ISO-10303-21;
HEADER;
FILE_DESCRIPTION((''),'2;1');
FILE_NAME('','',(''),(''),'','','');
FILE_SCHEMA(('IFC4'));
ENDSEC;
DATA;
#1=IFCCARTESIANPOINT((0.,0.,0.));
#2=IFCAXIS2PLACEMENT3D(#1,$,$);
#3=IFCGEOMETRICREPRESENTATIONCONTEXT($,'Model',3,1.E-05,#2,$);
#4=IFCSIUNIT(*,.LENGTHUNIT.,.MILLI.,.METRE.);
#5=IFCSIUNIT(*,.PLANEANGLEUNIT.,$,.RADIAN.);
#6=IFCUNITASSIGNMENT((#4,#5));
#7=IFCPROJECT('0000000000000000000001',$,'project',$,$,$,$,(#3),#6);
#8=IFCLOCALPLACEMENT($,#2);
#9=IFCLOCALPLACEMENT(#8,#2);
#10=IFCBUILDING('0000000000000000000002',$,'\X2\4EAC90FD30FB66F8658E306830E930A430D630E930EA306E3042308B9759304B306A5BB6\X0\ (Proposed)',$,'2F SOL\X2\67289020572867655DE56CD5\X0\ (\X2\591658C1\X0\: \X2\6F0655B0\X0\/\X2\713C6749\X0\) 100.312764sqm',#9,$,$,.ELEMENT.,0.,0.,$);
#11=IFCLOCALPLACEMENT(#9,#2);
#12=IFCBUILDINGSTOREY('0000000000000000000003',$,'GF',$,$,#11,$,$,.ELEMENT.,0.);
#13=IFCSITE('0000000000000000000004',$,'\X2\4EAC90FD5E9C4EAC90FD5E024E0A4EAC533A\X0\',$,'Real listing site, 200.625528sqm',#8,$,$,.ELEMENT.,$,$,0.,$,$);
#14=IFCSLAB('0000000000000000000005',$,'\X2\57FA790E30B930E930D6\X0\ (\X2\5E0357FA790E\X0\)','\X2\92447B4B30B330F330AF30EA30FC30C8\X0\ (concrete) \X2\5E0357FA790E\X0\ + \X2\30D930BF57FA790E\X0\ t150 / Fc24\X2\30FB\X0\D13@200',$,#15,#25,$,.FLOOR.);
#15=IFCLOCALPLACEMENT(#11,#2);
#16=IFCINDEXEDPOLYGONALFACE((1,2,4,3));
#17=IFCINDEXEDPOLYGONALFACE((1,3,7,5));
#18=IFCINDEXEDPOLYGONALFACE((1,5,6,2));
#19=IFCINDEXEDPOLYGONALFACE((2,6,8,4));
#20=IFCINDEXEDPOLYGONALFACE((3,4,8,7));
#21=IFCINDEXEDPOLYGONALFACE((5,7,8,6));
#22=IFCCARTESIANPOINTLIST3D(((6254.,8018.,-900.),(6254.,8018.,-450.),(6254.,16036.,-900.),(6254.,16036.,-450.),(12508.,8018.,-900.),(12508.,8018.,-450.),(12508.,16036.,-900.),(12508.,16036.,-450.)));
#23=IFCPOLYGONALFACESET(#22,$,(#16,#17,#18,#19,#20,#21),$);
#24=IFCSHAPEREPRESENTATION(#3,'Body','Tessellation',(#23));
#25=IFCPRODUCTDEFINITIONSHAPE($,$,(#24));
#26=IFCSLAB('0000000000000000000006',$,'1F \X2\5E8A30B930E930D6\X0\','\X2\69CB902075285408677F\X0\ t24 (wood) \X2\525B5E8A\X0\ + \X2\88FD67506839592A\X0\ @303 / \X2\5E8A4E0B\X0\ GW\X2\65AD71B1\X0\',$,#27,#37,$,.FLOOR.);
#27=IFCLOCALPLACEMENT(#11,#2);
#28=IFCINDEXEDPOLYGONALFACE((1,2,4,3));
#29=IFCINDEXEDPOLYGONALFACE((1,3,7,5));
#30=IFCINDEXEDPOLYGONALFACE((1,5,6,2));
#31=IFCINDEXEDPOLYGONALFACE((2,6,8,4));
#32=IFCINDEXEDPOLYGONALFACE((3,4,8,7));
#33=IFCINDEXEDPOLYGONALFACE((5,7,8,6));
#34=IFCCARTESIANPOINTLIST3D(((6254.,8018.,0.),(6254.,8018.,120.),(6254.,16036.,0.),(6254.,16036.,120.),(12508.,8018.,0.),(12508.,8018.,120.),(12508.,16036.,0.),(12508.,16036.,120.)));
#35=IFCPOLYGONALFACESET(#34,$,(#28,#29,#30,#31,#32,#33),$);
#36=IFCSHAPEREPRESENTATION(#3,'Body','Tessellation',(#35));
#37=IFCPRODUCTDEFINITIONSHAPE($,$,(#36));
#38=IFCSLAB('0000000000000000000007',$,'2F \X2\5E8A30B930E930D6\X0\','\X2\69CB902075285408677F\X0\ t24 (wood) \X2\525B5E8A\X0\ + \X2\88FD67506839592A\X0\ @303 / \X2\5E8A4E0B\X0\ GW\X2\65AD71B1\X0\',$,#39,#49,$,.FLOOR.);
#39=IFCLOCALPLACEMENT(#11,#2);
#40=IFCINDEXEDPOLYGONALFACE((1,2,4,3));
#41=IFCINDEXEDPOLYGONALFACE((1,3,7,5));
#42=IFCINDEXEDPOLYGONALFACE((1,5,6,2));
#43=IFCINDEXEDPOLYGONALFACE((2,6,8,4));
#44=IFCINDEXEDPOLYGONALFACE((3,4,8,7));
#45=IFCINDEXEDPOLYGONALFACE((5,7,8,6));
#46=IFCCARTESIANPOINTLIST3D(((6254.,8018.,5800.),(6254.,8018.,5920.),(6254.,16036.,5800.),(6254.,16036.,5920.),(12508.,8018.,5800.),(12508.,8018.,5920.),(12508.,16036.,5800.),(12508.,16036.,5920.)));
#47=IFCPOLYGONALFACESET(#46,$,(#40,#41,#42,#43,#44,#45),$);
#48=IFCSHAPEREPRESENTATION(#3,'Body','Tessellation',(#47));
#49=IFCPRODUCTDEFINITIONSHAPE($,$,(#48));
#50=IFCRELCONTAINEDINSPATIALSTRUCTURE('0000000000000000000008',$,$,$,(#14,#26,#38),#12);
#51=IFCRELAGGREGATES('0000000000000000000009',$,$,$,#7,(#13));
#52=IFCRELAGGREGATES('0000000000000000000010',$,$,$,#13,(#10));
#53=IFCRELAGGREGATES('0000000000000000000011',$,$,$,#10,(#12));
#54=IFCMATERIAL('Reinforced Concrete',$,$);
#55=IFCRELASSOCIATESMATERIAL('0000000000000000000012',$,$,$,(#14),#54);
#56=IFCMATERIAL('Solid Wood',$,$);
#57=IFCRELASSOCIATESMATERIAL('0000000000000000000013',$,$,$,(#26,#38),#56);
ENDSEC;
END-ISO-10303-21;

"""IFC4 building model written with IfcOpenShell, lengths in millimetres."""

from ifc_helpers import new_model, si_unit, frame, frame_2d, origin, place, context, project, spatial, rectangle, extrude, material, element, save


model = new_model("IFC4")

# Units and contexts
model_context = context("Model", 3, precision=1e-05, world=origin())
ifc_project = project(units=[si_unit("LENGTHUNIT", "METRE", prefix="MILLI"), si_unit("PLANEANGLEUNIT", "RADIAN")], contexts=[model_context])

# Site, building, storey
site_placement = place(None, origin())
site = spatial("IfcSite", under=ifc_project, at=site_placement, Name="京都府京都市上京区", ObjectType="Real listing site, 200.625528sqm", CompositionType="ELEMENT", RefElevation=0.0)
building_placement = place(site_placement, origin())
building = spatial("IfcBuilding", under=site, at=building_placement, Name="京都・書斎とライブラリのある静かな家 (Proposed)", ObjectType="2F SOL木造在来工法 (外壁: 漆喰/焼杉) 100.312764sqm", CompositionType="ELEMENT", ElevationOfRefHeight=0.0, ElevationOfTerrain=0.0)
storey_placement = place(building_placement, origin())
storey = spatial("IfcBuildingStorey", under=building, at=storey_placement, Name="GF", CompositionType="ELEMENT", Elevation=0.0)

# Slabs
ifc_material_1 = material(Name="Reinforced Concrete")
slab_1_placement = place(storey_placement, frame((3127.0, 4009.0, -450.0)))
element("IfcSlab", 1, at=slab_1_placement, inside=storey, material=ifc_material_1, Name="基礎スラブ (布基礎)", Description="鉄筋コンクリート (concrete) 布基礎 + ベタ基礎 t150 / Fc24・D13@200", PredefinedType="FLOOR", context=model_context, shape_type="SweptSolid", body=[
    extrude(rectangle(XDim=6254.0, YDim=8018.0, at=frame_2d((3127.0, 4009.0))), frame((3127.0, 4009.0, -450.0)), (0.0, 0.0, 1.0), 450.0),
])
ifc_material_2 = material(Name="Solid Wood")
slab_2_placement = place(storey_placement, frame((3127.0, 4009.0, 0.0)))
element("IfcSlab", 2, at=slab_2_placement, inside=storey, material=ifc_material_2, Name="1F 床スラブ", Description="構造用合板 t24 (wood) 剛床 + 製材根太 @303 / 床下 GW断熱", PredefinedType="FLOOR", context=model_context, shape_type="SweptSolid", body=[
    extrude(rectangle(XDim=6254.0, YDim=8018.0, at=frame_2d((3127.0, 4009.0))), frame((3127.0, 4009.0, 0.0)), (0.0, 0.0, 1.0), 120.0),
])
slab_3_placement = place(storey_placement, frame((3127.0, 4009.0, 2900.0)))
element("IfcSlab", 3, at=slab_3_placement, inside=storey, material=ifc_material_2, Name="2F 床スラブ", Description="構造用合板 t24 (wood) 剛床 + 製材根太 @303 / 床下 GW断熱", PredefinedType="FLOOR", context=model_context, shape_type="SweptSolid", body=[
    extrude(rectangle(XDim=6254.0, YDim=8018.0, at=frame_2d((3127.0, 4009.0))), frame((3127.0, 4009.0, 2900.0)), (0.0, 0.0, 1.0), 120.0),
])

save(model, "model.ifc")
